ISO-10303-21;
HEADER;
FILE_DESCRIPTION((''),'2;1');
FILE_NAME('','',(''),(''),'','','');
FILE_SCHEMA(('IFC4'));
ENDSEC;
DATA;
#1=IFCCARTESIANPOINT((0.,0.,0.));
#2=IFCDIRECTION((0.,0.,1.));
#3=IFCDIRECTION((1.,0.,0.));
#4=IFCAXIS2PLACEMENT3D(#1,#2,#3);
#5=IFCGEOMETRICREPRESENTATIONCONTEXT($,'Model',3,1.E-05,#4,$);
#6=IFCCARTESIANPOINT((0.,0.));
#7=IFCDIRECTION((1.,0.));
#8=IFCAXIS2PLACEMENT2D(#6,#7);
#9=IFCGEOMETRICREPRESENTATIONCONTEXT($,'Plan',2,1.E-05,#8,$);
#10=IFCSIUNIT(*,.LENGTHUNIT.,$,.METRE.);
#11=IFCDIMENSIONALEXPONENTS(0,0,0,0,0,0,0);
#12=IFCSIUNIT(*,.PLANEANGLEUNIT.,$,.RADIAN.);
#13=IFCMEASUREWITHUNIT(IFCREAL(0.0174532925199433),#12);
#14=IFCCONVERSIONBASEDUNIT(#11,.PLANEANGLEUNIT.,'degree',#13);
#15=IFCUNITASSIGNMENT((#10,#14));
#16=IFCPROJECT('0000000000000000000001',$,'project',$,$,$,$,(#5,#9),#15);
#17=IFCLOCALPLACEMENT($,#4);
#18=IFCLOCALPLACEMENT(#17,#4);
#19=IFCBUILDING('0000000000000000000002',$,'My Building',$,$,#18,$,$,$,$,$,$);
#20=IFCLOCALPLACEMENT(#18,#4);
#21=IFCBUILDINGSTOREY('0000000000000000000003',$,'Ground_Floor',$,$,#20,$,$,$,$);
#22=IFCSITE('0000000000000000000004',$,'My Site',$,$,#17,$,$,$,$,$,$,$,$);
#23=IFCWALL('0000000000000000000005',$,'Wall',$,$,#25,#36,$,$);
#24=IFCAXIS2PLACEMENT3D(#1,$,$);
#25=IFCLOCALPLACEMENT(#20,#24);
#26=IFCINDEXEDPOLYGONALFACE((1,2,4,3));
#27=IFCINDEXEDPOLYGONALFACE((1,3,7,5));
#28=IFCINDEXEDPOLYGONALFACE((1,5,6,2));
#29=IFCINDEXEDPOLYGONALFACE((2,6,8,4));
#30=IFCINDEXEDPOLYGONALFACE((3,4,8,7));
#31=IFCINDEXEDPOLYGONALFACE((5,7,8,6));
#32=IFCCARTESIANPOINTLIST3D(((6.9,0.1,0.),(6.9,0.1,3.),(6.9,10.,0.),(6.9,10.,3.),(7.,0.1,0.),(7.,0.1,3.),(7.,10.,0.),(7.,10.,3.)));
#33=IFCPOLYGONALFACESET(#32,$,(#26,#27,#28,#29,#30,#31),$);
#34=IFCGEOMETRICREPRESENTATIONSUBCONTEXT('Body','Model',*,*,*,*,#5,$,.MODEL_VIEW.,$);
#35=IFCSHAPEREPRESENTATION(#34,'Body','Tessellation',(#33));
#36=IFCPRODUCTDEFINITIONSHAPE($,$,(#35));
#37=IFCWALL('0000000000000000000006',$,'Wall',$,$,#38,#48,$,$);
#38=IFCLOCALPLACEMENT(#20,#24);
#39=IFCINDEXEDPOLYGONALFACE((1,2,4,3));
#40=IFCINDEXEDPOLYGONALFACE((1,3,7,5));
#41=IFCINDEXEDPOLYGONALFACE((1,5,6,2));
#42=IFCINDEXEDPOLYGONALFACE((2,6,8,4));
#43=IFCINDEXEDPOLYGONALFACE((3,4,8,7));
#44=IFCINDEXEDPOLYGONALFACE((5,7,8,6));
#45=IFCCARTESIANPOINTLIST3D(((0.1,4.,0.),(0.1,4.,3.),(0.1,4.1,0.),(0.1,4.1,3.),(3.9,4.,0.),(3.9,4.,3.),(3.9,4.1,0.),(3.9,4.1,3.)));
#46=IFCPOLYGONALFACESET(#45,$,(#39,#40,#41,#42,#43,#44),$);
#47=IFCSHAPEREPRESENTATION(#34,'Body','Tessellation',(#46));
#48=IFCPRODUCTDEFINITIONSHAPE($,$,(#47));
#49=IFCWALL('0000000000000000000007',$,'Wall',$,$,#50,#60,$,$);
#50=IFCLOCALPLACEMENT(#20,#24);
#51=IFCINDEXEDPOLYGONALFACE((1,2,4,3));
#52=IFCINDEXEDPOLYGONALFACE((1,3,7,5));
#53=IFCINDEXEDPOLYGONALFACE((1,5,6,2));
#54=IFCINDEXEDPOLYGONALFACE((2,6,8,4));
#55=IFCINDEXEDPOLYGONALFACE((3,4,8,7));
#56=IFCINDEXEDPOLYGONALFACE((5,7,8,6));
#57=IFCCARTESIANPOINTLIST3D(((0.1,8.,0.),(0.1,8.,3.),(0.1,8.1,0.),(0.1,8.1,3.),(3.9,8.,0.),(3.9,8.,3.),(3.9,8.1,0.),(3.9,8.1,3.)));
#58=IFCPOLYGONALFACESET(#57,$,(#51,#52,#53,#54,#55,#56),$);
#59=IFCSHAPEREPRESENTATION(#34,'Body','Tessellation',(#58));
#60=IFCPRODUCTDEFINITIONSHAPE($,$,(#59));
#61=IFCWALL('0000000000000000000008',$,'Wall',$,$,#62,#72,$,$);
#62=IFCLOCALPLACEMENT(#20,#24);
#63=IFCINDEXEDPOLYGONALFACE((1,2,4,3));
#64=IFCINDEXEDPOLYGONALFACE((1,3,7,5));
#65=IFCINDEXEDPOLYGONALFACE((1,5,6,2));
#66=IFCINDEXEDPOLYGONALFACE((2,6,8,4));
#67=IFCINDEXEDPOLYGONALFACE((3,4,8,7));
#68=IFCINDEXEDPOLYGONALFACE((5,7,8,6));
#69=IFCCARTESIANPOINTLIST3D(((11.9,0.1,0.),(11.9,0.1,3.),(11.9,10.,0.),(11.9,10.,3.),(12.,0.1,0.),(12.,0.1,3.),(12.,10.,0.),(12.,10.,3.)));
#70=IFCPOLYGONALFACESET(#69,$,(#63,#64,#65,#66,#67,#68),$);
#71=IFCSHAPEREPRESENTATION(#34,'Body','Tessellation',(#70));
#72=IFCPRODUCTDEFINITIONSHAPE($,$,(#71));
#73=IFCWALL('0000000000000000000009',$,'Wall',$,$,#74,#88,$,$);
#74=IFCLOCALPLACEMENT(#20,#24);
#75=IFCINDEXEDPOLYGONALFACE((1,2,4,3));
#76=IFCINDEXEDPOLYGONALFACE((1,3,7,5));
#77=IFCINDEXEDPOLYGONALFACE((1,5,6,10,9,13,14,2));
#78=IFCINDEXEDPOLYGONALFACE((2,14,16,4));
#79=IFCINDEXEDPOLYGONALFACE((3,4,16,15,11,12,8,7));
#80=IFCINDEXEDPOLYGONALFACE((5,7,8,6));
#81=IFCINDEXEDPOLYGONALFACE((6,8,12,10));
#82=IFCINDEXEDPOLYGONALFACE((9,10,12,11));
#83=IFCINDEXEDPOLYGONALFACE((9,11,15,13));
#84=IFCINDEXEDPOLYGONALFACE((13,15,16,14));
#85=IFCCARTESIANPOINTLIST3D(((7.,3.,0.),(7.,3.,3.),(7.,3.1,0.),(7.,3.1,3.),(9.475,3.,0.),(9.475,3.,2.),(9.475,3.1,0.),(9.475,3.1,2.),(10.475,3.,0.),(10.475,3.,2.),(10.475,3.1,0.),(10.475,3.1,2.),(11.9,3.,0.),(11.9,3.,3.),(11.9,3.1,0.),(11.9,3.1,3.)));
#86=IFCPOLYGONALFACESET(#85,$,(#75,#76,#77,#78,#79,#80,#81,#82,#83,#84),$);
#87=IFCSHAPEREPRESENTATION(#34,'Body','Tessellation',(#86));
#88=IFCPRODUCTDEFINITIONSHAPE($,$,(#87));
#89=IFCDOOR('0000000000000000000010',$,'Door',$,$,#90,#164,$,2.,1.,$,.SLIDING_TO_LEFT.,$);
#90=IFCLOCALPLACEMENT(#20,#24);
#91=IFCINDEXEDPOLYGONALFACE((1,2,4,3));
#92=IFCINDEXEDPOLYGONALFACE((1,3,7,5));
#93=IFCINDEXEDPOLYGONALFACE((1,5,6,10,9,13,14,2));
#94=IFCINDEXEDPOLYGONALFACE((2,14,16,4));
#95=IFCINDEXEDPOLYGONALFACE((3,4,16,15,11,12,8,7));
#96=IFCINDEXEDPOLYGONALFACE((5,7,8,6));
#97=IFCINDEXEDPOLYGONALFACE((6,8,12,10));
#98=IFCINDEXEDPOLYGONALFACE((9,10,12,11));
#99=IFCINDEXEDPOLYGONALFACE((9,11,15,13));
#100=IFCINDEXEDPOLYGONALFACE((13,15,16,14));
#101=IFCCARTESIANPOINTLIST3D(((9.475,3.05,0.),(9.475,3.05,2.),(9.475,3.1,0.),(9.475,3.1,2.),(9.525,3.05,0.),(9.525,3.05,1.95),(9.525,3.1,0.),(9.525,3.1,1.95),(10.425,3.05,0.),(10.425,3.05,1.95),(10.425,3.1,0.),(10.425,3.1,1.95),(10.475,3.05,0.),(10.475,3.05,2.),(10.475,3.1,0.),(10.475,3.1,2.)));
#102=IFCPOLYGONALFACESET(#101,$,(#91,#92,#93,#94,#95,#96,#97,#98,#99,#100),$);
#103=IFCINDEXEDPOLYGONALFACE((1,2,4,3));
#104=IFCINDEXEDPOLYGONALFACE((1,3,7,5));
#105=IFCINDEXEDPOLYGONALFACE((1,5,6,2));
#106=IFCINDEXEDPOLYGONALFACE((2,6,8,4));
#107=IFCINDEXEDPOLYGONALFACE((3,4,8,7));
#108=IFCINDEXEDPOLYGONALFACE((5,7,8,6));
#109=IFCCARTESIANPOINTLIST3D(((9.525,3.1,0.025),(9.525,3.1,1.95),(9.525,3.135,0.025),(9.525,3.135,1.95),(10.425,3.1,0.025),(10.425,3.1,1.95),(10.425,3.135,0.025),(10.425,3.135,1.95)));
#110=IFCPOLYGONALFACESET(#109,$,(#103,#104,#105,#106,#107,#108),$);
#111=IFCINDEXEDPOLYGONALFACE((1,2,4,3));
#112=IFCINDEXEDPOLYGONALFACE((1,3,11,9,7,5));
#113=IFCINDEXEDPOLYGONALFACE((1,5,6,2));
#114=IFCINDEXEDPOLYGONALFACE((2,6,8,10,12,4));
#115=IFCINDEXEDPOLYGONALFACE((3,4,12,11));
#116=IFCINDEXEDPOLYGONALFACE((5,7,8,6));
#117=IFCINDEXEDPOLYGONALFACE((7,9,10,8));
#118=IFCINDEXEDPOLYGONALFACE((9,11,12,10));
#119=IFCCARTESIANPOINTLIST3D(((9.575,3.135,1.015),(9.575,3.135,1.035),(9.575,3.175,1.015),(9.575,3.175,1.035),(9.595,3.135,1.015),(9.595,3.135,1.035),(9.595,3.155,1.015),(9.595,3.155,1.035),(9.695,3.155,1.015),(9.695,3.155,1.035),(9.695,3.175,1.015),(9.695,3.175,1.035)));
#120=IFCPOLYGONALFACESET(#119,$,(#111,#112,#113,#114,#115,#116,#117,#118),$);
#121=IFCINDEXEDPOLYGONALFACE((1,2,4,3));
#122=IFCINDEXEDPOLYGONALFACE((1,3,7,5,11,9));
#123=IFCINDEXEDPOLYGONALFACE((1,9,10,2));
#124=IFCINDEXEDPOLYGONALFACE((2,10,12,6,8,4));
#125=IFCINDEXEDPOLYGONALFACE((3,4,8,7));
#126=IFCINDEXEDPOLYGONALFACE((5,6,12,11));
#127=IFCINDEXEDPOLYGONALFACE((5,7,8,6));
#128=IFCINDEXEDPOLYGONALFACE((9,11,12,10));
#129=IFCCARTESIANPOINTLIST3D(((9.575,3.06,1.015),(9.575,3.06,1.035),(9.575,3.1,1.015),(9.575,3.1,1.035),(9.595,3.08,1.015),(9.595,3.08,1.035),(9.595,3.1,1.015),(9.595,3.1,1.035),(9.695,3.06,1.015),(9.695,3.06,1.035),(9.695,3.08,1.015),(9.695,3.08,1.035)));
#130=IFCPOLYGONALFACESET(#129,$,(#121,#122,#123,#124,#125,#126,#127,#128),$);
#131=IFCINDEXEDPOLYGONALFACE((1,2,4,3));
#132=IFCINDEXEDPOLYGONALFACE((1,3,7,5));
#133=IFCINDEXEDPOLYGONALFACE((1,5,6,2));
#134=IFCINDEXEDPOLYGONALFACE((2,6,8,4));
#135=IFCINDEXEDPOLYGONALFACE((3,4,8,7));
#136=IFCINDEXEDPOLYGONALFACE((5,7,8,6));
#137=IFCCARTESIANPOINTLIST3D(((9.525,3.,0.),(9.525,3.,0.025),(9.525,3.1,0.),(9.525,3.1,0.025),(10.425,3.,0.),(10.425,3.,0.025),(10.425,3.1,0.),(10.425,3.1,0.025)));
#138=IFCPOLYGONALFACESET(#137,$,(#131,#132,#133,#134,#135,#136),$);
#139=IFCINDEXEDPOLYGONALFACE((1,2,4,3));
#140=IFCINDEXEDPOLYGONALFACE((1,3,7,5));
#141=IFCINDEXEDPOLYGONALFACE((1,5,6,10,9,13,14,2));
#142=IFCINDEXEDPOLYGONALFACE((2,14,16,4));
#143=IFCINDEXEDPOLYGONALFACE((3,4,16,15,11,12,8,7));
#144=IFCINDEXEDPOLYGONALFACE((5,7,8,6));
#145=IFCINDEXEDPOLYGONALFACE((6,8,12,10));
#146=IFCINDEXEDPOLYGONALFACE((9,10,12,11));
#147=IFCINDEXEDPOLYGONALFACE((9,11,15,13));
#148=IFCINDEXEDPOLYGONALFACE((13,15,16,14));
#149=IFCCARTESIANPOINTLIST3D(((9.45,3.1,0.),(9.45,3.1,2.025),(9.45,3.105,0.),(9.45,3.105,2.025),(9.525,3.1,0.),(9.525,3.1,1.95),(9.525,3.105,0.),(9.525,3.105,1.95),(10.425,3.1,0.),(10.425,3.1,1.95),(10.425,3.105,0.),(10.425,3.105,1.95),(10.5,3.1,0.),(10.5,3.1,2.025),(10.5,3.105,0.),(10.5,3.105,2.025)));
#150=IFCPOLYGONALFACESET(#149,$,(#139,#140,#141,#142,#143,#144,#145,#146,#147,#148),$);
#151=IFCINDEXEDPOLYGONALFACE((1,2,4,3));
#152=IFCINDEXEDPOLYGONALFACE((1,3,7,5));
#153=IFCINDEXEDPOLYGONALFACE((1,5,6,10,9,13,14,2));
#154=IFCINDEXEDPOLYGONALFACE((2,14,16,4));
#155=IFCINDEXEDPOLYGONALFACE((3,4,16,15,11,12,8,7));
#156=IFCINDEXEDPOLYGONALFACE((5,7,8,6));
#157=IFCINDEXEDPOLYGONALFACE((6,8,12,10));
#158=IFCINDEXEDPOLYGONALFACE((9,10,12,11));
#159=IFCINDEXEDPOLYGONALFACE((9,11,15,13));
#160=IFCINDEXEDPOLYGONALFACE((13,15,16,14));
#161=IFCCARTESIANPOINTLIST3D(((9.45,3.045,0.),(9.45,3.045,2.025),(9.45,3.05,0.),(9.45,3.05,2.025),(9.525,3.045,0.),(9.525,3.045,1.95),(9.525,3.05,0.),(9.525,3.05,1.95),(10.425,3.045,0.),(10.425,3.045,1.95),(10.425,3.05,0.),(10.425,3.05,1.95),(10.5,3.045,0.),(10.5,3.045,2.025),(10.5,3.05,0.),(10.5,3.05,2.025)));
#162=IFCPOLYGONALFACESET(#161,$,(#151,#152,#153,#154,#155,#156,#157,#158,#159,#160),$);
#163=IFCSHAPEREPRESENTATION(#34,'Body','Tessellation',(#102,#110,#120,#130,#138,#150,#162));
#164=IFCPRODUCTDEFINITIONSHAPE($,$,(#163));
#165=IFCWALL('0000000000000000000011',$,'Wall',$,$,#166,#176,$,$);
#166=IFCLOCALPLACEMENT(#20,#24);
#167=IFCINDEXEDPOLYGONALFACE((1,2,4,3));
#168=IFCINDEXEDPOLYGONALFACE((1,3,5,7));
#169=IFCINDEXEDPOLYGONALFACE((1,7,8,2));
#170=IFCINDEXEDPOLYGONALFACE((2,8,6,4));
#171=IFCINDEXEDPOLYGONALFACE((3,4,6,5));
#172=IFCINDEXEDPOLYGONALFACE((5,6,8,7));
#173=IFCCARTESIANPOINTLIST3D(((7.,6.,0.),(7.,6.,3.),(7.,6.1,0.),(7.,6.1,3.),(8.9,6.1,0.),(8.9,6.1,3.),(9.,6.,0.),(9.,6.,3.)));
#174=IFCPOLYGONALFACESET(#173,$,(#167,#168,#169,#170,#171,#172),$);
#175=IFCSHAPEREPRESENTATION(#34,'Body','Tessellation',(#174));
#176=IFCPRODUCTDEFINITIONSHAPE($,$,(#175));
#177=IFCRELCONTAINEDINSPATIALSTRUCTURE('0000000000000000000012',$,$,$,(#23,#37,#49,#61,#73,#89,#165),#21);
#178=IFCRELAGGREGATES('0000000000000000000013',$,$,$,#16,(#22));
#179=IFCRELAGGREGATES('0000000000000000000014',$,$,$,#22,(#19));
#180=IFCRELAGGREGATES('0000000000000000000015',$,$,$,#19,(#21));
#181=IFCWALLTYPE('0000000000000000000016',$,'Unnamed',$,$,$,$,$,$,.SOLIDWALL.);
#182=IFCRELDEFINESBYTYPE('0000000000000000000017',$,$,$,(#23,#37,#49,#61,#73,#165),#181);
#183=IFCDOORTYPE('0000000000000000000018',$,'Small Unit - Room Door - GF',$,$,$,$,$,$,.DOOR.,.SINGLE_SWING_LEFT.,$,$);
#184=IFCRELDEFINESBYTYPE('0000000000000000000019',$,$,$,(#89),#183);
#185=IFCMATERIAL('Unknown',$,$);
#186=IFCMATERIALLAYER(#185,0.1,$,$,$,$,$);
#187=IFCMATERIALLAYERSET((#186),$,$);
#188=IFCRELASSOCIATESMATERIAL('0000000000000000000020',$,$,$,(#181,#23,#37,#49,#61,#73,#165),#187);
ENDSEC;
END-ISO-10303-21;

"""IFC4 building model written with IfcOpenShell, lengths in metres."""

from ifc_helpers import new_model, entity, si_unit, converted_unit, frame, origin_with_axes, origin_2d_with_axis, place, context, subcontext, project, spatial, line, indexed_curve, outline, extrude, shape, source, transform, mapped, material, layer, layer_set, layer_usage, type_object, type_shapes, element, fill, save


model = new_model("IFC4")

# Units and contexts
model_context = context("Model", 3, precision=1e-05, world=origin_with_axes())
plan_context = context("Plan", 2, precision=1e-05, world=origin_2d_with_axis())
body_context_1 = subcontext(model_context, "Body", "Model", "MODEL_VIEW")
body_context_2 = subcontext(plan_context, "Body", "Plan", "PLAN_VIEW")
ifc_project = project(units=[si_unit("LENGTHUNIT", "METRE"), converted_unit("PLANEANGLEUNIT", "degree", entity("IfcReal", 0.0174532925199433), si_unit("PLANEANGLEUNIT", "RADIAN"), dimensions=[0, 0, 0, 0, 0, 0, 0])], contexts=[model_context, plan_context])

# Site, building, storey
site_placement = place(None, origin_with_axes())
site = spatial("IfcSite", under=ifc_project, at=site_placement, Name="My Site")
building_placement = place(site_placement, origin_with_axes())
building = spatial("IfcBuilding", under=site, at=building_placement, Name="My Building")
storey_placement = place(building_placement, origin_with_axes())
storey = spatial("IfcBuildingStorey", under=building, at=storey_placement, Name="Ground_Floor")

# Shared definitions
ifc_material = material(Name="Unknown")
ifc_layer = layer(ifc_material, 0.1)
ifc_layer_set = layer_set([ifc_layer])
wall_type = type_object("IfcWallType", Name="Unnamed", PredefinedType="SOLIDWALL", material=ifc_layer_set)

# Walls
ifc_layer_usage_1 = layer_usage(ifc_layer_set, "AXIS2", "POSITIVE", 0.0)
wall_1_placement = place(storey_placement, frame((7.0, 0.0, 0.0), z_axis=(0.0, 0.0, 1.0), x_axis=(0.0, 1.0, 0.0)))
element("IfcWall", 1, at=wall_1_placement, inside=storey, type_object=wall_type, material=ifc_layer_usage_1, Name="Wall", context=body_context_1, shape_type="SweptSolid", body=[
    extrude(outline(indexed_curve([(0.1, 0.0), (0.1, 0.1), (10.0, 0.1), (10.0, 0.0)], segments=[line(1, 2, 3, 4, 1)])), origin_with_axes(), (0.0, 0.0, 1.0), 3.0),
])
ifc_layer_usage_2 = layer_usage(ifc_layer_set, "AXIS2", "POSITIVE", 0.0)
wall_2_placement = place(storey_placement, frame((0.0, 4.0, 0.0), z_axis=(0.0, 0.0, 1.0), x_axis=(1.0, 0.0, 0.0)))
element("IfcWall", 2, at=wall_2_placement, inside=storey, type_object=wall_type, material=ifc_layer_usage_2, Name="Wall", context=body_context_1, shape_type="SweptSolid", body=[
    extrude(outline(indexed_curve([(0.1, 0.0), (0.1, 0.1), (3.9, 0.1), (3.9, 0.0)], segments=[line(1, 2, 3, 4, 1)])), origin_with_axes(), (0.0, 0.0, 1.0), 3.0),
])
ifc_layer_usage_3 = layer_usage(ifc_layer_set, "AXIS2", "POSITIVE", 0.0)
wall_3_placement = place(storey_placement, frame((0.0, 8.0, 0.0), z_axis=(0.0, 0.0, 1.0), x_axis=(1.0, 0.0, 0.0)))
element("IfcWall", 3, at=wall_3_placement, inside=storey, type_object=wall_type, material=ifc_layer_usage_3, Name="Wall", context=body_context_1, shape_type="SweptSolid", body=[
    extrude(outline(indexed_curve([(0.1, 0.0), (0.1, 0.1), (3.9, 0.1), (3.9, 0.0)], segments=[line(1, 2, 3, 4, 1)])), origin_with_axes(), (0.0, 0.0, 1.0), 3.0),
])
ifc_layer_usage_4 = layer_usage(ifc_layer_set, "AXIS2", "POSITIVE", 0.0)
wall_4_placement = place(storey_placement, frame((12.0, 0.0, 0.0), z_axis=(0.0, 0.0, 1.0), x_axis=(0.0, 1.0, 0.0)))
element("IfcWall", 4, at=wall_4_placement, inside=storey, type_object=wall_type, material=ifc_layer_usage_4, Name="Wall", context=body_context_1, shape_type="SweptSolid", body=[
    extrude(outline(indexed_curve([(0.1, 0.0), (0.1, 0.1), (10.0, 0.1), (10.0, 0.0)], segments=[line(1, 2, 3, 4, 1)])), origin_with_axes(), (0.0, 0.0, 1.0), 3.0),
])

# Wall, opening, door
ifc_layer_usage_5 = layer_usage(ifc_layer_set, "AXIS2", "POSITIVE", 0.0)
wall_5_placement = place(storey_placement, frame((7.0, 3.0, 0.0), z_axis=(0.0, 0.0, 1.0), x_axis=(1.0, 0.0, 0.0)))
wall_5 = element("IfcWall", 5, at=wall_5_placement, inside=storey, type_object=wall_type, material=ifc_layer_usage_5, Name="Wall", context=body_context_1, shape_type="SweptSolid", body=[
    extrude(outline(indexed_curve([(0.0, 0.0), (0.0, 0.1), (4.9, 0.1), (4.9, 0.0)], segments=[line(1, 2, 3, 4, 1)])), origin_with_axes(), (0.0, 0.0, 1.0), 3.0),
])
shared_shape_1 = source(origin_with_axes(), body_context_1, "Body", "SweptSolid", [
    extrude(outline(indexed_curve([(0.0, 0.0), (1.0, 0.0), (1.0, 2.0), (0.0, 2.0)], segments=[line(1, 2, 3, 4, 1)])), frame((0.0, -0.6, 0.0), z_axis=(0.0, -1.0, 0.0), x_axis=(1.0, 0.0, 0.0)), (0.0, 0.0, -1.0), 1.2),
])
opening_1_placement = place(wall_5_placement, frame((3.475, 0.1, 0.0), z_axis=(0.0, 0.0, 1.0), x_axis=(-1.0, 0.0, 0.0)))
opening_1 = element("IfcOpeningElement", 6, at=opening_1_placement, cuts=wall_5, PredefinedType="OPENING", context=body_context_1, shape_type="MappedRepresentation", body=[
    mapped(shared_shape_1, transform((0.0, 0.0, 0.0), x_axis=(1.0, 0.0, 0.0), y_axis=(0.0, 1.0, 0.0), z_axis=(0.0, 0.0, 1.0), scale=1.0)),
])
door_type_1 = type_object("IfcDoorType", Name="Small Unit - Room Door - GF", OperationType="SINGLE_SWING_LEFT", PredefinedType="DOOR")
shared_shape_2 = source(origin_with_axes(), body_context_1, "Body", "SweptSolid", [
    extrude(outline(indexed_curve([(0.0, 0.0), (0.0, 2.0), (1.0, 2.0), (1.0, 0.0), (0.95, 0.0), (0.95, 1.95), (0.05, 1.95), (0.05, 0.0)], segments=[line(1, 2, 3, 4, 5, 6, 7, 8, 1)])), frame((0.0, 0.0, 0.0), z_axis=(0.0, -1.0, 0.0), x_axis=(1.0, 0.0, 0.0)), (0.0, 0.0, -1.0), 0.05),
    extrude(outline(indexed_curve([(0.0, 0.0), (0.9, 0.0), (0.9, 0.035), (0.0, 0.035)], segments=[line(1, 2, 3, 4, 1)])), frame((0.05, -0.035, 0.025), z_axis=(0.0, 0.0, 1.0), x_axis=(1.0, 0.0, 0.0)), (0.0, 0.0, 1.0), 1.925),
    extrude(outline(indexed_curve([(0.0, 0.0), (0.0, -0.04), (-0.12, -0.04), (-0.12, -0.02), (-0.02, -0.02), (-0.02, 0.0)], segments=[line(1, 2, 3, 4, 5, 6, 1)])), frame((0.9, -0.035, 1.015), z_axis=(0.0, 0.0, 1.0), x_axis=(1.0, 0.0, 0.0)), (0.0, 0.0, 1.0), 0.02),
    extrude(outline(indexed_curve([(0.0, 0.0), (0.0, 0.04), (-0.12, 0.04), (-0.12, 0.02), (-0.02, 0.02), (-0.02, 0.0)], segments=[line(1, 2, 3, 4, 5, 6, 1)])), frame((0.9, 0.0, 1.015), z_axis=(0.0, 0.0, 1.0), x_axis=(1.0, 0.0, 0.0)), (0.0, 0.0, 1.0), 0.02),
    extrude(outline(indexed_curve([(0.0, 0.0), (0.9, 0.0), (0.9, 0.1), (0.0, 0.1)], segments=[line(1, 2, 3, 4, 1)])), frame((0.05, 0.0, 0.0), z_axis=(0.0, 0.0, 1.0), x_axis=(1.0, 0.0, 0.0)), (0.0, 0.0, 1.0), 0.025),
    extrude(outline(indexed_curve([(0.0, 0.0), (0.0, 2.025), (1.05, 2.025), (1.05, 0.0), (0.975, 0.0), (0.975, 1.95), (0.075, 1.95), (0.075, 0.0)], segments=[line(1, 2, 3, 4, 5, 6, 7, 8, 1)])), frame((-0.025, -0.005, 0.0), z_axis=(0.0, -1.0, 0.0), x_axis=(1.0, 0.0, 0.0)), (0.0, 0.0, -1.0), 0.005),
    extrude(outline(indexed_curve([(0.0, 0.0), (0.0, 2.025), (1.05, 2.025), (1.05, 0.0), (0.975, 0.0), (0.975, 1.95), (0.075, 1.95), (0.075, 0.0)], segments=[line(1, 2, 3, 4, 5, 6, 7, 8, 1)])), frame((-0.025, 0.05, 0.0), z_axis=(0.0, -1.0, 0.0), x_axis=(1.0, 0.0, 0.0)), (0.0, 0.0, -1.0), 0.005),
])
shared_shape_3 = source(origin_with_axes(), body_context_2, "Body", "Curve2D", [
    entity("IfcIndexedPolyCurve", entity("IfcCartesianPointList2D", [[0.0, 0.0], [0.05, 0.0], [0.05, 0.05], [0.0, 0.05]]), [entity("IfcLineIndex", [1, 2, 3, 4, 1])]),
    entity("IfcIndexedPolyCurve", entity("IfcCartesianPointList2D", [[1.0, 0.0], [0.95, 0.0], [0.95, 0.05], [1.0, 0.05]]), [entity("IfcLineIndex", [1, 2, 3, 4, 1])]),
    entity("IfcIndexedPolyCurve", entity("IfcCartesianPointList2D", [[-0.4, -0.035], [0.5, -0.035], [0.5, 0.0], [-0.4, 0.0]]), [entity("IfcLineIndex", [1, 2, 3, 4, 1])]),
])
type_shapes(door_type_1, [shared_shape_2, shared_shape_3])
door_1_placement = place(opening_1_placement, frame((0.0, 0.0, 0.0), z_axis=(0.0, 0.0, 1.0), x_axis=(1.0, 0.0, 0.0)))
door_1 = element("IfcDoor", 7, at=door_1_placement, inside=storey, type_object=door_type_1, Name="Door", OperationType="SLIDING_TO_LEFT", OverallHeight=2.0, OverallWidth=1.0, shapes=[
    shape(body_context_1, "Body", "MappedRepresentation", [mapped(shared_shape_2, transform((0.0, 0.0, 0.0), x_axis=(1.0, 0.0, 0.0), y_axis=(0.0, 1.0, 0.0), z_axis=(0.0, 0.0, 1.0), scale=1.0))]),
    shape(body_context_2, "Body", "MappedRepresentation", [mapped(shared_shape_3, transform((0.0, 0.0, 0.0), x_axis=(1.0, 0.0, 0.0), y_axis=(0.0, 1.0, 0.0), z_axis=(0.0, 0.0, 1.0), scale=1.0))]),
])
fill(opening_1, door_1)

# Wall
ifc_layer_usage_6 = layer_usage(ifc_layer_set, "AXIS2", "POSITIVE", 0.0)
wall_6_placement = place(storey_placement, frame((7.0, 6.0, 0.0), z_axis=(0.0, 0.0, 1.0), x_axis=(1.0, 0.0, 0.0)))
element("IfcWall", 8, at=wall_6_placement, inside=storey, type_object=wall_type, material=ifc_layer_usage_6, Name="Wall", context=body_context_1, shape_type="SweptSolid", body=[
    extrude(outline(indexed_curve([(0.0, 0.0), (0.0, 0.1), (1.9, 0.1), (2.0, 0.0)], segments=[line(1, 2, 3, 4, 1)])), origin_with_axes(), (0.0, 0.0, 1.0), 3.0),
])

save(model, "model.ifc")
